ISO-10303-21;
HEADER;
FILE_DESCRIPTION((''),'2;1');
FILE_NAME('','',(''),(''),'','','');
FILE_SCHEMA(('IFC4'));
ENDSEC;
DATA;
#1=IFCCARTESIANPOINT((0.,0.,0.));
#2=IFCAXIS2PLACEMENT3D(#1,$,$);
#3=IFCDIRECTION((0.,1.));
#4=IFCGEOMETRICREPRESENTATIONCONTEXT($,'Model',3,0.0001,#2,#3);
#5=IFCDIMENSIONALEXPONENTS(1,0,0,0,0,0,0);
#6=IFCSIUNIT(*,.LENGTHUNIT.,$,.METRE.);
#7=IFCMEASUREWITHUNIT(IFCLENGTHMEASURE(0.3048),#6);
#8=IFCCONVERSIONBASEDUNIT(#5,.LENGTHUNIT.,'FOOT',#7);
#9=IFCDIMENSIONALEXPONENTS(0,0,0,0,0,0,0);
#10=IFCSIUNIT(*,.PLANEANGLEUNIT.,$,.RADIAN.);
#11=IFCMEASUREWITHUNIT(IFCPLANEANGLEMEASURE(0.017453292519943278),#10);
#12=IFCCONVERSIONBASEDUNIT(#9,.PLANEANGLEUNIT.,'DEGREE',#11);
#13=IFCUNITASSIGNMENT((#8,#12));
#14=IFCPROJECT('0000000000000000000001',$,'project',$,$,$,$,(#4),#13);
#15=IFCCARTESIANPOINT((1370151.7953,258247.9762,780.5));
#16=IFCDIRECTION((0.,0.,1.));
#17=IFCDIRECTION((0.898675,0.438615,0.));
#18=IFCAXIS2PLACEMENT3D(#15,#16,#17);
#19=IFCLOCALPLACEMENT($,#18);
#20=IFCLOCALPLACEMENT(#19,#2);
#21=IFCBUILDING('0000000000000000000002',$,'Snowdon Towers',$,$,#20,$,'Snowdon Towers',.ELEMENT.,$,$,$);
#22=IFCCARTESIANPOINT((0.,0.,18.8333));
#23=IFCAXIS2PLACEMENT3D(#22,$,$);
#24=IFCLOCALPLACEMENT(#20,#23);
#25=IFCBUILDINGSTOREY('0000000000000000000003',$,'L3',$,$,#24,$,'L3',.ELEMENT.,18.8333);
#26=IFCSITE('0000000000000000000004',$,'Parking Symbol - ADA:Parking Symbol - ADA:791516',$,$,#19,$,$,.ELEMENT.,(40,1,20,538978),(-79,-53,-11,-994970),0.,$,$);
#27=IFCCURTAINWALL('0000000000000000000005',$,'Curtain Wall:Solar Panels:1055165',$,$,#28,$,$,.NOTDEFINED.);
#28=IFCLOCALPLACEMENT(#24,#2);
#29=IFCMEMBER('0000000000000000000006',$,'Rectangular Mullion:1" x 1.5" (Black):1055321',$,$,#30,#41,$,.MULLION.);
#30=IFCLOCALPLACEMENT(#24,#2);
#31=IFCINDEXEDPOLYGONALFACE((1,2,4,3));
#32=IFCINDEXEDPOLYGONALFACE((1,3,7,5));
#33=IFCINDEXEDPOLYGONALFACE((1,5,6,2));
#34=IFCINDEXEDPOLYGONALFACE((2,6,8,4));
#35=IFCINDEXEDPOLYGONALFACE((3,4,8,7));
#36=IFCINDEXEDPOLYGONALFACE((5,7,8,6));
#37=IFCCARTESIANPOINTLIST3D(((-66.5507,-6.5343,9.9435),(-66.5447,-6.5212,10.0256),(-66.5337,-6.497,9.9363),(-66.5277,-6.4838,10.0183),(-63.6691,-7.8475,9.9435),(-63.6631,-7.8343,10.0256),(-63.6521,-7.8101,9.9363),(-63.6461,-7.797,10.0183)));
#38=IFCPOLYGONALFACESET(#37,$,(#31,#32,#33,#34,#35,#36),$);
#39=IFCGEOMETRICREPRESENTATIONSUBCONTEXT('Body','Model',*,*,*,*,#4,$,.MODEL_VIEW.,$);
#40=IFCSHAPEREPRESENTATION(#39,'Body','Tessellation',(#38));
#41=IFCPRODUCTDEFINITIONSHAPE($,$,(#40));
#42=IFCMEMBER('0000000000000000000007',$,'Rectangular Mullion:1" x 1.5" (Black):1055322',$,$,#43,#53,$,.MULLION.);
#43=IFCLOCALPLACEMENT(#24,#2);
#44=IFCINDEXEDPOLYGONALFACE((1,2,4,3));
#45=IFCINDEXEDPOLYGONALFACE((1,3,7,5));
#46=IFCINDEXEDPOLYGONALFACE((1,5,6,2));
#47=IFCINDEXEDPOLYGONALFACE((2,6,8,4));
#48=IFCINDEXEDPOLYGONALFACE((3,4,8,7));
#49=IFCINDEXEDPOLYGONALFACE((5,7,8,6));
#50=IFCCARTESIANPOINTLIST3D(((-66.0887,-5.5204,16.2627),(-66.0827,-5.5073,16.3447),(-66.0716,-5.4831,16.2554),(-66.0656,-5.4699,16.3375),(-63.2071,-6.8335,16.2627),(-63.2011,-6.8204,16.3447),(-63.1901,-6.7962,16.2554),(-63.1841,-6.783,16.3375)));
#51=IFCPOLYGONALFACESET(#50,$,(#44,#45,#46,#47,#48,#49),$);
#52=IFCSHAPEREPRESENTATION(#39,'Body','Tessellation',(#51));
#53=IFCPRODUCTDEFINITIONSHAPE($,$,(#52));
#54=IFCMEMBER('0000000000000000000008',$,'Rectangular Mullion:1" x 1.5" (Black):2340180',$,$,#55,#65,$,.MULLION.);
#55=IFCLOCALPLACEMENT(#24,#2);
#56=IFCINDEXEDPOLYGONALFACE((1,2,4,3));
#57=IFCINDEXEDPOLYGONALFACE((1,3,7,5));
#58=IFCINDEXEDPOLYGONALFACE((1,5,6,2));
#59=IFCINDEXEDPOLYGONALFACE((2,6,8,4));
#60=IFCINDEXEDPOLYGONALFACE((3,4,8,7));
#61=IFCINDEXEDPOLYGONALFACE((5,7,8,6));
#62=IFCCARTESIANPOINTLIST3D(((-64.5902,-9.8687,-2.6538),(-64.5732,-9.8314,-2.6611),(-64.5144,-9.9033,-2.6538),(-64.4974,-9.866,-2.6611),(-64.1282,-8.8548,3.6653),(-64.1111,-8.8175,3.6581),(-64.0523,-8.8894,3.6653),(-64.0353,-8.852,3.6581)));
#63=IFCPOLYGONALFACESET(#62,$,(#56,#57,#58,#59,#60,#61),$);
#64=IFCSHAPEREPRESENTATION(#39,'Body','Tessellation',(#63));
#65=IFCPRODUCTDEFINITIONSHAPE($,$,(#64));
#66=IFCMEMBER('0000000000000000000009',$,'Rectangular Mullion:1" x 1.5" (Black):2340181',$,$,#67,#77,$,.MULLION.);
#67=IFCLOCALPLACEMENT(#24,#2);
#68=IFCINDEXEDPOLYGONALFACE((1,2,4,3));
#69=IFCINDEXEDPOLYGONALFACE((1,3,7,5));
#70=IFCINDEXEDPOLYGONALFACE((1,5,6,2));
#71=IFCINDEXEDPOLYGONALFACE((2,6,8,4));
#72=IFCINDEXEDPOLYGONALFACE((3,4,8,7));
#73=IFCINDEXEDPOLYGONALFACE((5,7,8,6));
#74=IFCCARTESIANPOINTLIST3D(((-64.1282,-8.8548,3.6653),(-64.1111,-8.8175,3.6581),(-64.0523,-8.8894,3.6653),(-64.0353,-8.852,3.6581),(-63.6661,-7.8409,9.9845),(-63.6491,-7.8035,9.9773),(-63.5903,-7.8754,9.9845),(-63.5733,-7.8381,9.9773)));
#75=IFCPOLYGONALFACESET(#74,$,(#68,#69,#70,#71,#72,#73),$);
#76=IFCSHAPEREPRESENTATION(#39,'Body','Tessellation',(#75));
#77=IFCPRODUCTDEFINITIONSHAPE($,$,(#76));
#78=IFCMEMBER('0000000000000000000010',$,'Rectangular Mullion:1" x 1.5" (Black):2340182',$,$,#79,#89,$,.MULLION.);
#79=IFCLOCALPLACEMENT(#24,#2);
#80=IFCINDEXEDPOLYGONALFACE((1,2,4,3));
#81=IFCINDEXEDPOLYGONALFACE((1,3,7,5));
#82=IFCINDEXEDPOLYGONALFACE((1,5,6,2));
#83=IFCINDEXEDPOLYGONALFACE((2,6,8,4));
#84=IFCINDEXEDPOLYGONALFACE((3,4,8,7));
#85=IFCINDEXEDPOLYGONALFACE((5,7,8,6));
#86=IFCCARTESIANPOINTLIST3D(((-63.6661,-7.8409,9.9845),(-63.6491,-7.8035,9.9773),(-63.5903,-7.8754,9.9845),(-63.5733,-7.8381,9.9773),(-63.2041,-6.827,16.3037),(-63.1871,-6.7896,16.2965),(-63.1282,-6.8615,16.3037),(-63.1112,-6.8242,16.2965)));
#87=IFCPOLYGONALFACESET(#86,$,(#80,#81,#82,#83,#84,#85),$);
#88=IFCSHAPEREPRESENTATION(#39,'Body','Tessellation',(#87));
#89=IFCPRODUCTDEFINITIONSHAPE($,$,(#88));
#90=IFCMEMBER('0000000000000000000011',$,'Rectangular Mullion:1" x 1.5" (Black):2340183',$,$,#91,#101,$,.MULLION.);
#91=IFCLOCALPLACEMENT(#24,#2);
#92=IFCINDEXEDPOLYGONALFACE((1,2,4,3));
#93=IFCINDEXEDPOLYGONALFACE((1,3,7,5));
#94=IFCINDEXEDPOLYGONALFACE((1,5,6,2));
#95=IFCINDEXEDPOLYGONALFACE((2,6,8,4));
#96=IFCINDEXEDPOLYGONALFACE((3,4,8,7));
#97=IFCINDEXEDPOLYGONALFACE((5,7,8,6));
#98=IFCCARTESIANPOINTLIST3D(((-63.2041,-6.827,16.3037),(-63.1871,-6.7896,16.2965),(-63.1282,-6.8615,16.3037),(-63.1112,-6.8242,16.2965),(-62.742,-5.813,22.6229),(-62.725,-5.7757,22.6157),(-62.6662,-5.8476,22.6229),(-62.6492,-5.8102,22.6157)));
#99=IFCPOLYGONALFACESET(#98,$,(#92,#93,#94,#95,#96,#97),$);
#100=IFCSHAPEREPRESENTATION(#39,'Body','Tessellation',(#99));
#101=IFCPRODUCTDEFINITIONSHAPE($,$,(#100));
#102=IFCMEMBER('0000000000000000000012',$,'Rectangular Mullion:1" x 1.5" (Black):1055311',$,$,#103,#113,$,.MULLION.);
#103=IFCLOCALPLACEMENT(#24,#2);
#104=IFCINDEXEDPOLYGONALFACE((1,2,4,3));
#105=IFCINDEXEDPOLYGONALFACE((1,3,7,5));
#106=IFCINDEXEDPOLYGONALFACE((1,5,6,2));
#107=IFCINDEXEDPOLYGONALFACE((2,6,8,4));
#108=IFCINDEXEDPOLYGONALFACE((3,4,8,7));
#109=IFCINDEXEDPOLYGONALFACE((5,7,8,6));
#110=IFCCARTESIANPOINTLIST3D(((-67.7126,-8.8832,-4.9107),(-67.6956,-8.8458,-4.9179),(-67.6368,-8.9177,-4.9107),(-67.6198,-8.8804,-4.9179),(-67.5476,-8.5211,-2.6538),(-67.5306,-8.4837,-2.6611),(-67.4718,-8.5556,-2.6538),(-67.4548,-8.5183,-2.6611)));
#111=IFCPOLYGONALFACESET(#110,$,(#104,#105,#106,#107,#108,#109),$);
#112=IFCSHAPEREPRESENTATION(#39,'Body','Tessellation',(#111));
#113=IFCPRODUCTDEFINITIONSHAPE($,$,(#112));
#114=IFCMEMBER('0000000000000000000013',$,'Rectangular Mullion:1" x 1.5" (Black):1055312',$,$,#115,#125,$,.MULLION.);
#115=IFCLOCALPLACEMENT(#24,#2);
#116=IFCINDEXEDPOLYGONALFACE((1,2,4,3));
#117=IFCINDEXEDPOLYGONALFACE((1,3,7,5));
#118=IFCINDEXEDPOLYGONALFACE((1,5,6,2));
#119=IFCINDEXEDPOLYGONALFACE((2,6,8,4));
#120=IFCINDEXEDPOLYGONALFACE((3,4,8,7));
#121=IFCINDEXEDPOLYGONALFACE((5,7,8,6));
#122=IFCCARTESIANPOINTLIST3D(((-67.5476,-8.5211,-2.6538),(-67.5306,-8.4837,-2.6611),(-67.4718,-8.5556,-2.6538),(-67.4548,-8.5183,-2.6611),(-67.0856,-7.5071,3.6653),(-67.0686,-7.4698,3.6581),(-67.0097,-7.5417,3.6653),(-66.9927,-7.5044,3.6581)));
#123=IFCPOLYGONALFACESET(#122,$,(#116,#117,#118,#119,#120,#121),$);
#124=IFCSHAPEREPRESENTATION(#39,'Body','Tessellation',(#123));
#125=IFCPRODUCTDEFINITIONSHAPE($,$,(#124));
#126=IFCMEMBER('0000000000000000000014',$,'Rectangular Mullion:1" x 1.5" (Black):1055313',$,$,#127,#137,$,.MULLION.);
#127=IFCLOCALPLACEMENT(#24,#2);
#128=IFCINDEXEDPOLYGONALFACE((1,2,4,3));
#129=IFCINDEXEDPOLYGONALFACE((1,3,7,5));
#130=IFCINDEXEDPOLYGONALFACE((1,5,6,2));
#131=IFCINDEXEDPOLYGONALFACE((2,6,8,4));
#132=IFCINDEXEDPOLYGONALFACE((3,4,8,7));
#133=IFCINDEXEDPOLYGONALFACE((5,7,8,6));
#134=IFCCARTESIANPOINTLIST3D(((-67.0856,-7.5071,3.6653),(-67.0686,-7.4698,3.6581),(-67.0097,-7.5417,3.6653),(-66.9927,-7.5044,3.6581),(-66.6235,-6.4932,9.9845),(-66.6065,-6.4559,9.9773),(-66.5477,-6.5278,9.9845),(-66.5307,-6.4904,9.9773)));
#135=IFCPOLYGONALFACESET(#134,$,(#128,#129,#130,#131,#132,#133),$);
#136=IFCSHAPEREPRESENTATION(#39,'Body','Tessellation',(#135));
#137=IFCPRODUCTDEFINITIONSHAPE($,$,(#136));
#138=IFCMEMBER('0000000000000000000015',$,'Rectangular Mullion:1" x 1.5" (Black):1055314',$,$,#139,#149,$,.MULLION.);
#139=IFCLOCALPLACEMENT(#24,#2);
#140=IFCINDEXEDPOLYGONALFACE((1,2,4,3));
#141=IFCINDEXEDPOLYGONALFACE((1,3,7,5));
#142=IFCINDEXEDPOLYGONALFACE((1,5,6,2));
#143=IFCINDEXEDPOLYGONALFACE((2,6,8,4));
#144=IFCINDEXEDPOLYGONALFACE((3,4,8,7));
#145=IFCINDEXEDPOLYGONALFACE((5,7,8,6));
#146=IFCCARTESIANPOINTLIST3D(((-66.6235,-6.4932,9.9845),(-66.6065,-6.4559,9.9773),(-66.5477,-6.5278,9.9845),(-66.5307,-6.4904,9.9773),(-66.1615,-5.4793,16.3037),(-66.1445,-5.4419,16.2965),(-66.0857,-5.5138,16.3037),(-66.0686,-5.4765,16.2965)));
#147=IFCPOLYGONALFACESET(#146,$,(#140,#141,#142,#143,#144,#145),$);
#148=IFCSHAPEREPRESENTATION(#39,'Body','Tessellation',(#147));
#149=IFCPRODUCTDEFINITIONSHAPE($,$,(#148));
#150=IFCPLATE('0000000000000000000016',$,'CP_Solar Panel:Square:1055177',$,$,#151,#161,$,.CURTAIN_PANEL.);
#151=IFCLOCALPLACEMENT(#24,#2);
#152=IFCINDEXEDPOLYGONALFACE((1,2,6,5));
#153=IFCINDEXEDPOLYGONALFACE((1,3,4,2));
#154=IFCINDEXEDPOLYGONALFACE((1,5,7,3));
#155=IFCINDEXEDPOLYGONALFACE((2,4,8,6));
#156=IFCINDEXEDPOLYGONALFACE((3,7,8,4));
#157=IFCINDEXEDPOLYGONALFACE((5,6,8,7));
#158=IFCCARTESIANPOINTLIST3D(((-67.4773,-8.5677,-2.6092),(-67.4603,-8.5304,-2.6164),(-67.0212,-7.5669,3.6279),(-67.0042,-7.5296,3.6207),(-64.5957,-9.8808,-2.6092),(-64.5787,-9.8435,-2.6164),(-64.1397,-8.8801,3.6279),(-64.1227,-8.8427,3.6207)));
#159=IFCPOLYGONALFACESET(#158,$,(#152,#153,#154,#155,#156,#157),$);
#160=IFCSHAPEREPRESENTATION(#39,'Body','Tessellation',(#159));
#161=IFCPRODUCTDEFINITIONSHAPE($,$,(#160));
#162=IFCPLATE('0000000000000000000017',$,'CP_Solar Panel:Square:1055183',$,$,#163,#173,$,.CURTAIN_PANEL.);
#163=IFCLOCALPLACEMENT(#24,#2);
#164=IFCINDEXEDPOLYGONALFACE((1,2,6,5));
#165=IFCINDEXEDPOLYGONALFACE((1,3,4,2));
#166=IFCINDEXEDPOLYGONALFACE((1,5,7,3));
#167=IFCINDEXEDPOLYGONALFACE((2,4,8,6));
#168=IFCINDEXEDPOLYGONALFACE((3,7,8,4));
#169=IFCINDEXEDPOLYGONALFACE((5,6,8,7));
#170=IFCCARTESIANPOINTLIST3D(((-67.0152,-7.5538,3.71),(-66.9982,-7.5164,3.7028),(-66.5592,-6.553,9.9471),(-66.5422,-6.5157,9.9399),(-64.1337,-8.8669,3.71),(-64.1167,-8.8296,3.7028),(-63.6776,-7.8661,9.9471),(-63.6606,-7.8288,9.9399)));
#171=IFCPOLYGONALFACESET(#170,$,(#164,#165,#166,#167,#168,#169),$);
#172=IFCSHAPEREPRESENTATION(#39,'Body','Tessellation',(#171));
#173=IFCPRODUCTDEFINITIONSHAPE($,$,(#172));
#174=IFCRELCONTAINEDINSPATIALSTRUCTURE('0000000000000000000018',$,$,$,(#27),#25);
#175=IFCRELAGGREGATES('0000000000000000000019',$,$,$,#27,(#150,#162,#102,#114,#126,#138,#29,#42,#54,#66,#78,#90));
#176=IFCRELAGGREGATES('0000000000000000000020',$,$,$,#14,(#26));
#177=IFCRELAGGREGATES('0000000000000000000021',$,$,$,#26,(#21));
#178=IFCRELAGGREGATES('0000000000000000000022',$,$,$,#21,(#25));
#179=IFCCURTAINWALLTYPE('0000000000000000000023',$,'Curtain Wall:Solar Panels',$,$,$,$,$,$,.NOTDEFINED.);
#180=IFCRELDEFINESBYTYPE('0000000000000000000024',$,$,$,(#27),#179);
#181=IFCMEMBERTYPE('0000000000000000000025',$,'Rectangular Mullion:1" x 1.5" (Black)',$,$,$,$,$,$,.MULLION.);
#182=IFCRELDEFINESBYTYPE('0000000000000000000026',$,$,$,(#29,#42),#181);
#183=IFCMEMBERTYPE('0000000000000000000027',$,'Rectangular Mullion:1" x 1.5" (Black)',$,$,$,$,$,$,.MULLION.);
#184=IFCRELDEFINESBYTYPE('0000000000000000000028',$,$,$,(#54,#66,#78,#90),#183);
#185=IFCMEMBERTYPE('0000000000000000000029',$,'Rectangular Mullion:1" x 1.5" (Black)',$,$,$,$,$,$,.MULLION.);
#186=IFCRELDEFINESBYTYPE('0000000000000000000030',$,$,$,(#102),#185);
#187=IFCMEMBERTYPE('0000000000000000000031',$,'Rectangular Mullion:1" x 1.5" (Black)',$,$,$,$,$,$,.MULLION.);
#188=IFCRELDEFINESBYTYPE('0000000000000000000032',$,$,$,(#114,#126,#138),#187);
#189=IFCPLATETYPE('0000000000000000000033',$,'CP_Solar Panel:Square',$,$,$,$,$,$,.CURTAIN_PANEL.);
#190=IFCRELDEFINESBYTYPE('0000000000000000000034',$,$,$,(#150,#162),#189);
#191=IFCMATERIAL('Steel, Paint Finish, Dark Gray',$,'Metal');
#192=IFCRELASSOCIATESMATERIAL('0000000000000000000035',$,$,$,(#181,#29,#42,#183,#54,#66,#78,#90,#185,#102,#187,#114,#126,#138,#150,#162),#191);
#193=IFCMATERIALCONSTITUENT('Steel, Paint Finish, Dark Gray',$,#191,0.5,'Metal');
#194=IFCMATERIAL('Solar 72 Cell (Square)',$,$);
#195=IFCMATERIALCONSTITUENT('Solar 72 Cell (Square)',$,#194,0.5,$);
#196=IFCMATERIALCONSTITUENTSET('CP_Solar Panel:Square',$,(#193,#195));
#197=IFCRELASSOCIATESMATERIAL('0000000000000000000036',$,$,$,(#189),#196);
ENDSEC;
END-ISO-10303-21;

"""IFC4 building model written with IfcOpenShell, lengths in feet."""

from ifc_helpers import new_model, entity, si_unit, converted_unit, direction, frame, origin, place, context, subcontext, project, spatial, indexed_curve, outline, extrude, source, transform, mapped, material, constituent, constituent_set, type_object, type_shapes, element, aggregate, save


model = new_model("IFC4")

# Units and contexts
model_context = context("Model", 3, precision=0.0001, world=origin(), true_north=direction((0.0, 1.0)))
body_context = subcontext(model_context, "Body", "Model", "MODEL_VIEW")
ifc_project = project(units=[converted_unit("LENGTHUNIT", "FOOT", entity("IfcLengthMeasure", 0.3048), si_unit("LENGTHUNIT", "METRE"), dimensions=[1, 0, 0, 0, 0, 0, 0]), converted_unit("PLANEANGLEUNIT", "DEGREE", entity("IfcPlaneAngleMeasure", 0.017453292519943278), si_unit("PLANEANGLEUNIT", "RADIAN"), dimensions=[0, 0, 0, 0, 0, 0, 0])], contexts=[model_context])

# Site, building, storey
site_placement = place(None, frame((1370151.7953, 258247.9762, 780.5), z_axis=(0.0, 0.0, 1.0), x_axis=(0.898675, 0.438615, 0.0)))
site = spatial("IfcSite", under=ifc_project, at=site_placement, Name="Parking Symbol - ADA:Parking Symbol - ADA:791516", CompositionType="ELEMENT", RefLatitude=(40, 1, 20, 538978), RefLongitude=(-79, -53, -11, -994970), RefElevation=0.0)
building_placement = place(site_placement, origin())
building = spatial("IfcBuilding", under=site, at=building_placement, Name="Snowdon Towers", LongName="Snowdon Towers", CompositionType="ELEMENT")
storey_placement = place(building_placement, frame((0.0, 0.0, 18.8333)))
storey = spatial("IfcBuildingStorey", under=building, at=storey_placement, Name="L3", LongName="L3", CompositionType="ELEMENT", Elevation=18.8333)

# Curtain wall, members
curtain_wall_type_1 = type_object("IfcCurtainWallType", Name="Curtain Wall:Solar Panels", PredefinedType="NOTDEFINED")
curtain_wall_1_placement = place(storey_placement, frame((0.0, 0.0, -18.8333)))
curtain_wall_1 = element("IfcCurtainWall", 1, at=curtain_wall_1_placement, inside=storey, type_object=curtain_wall_type_1, Name="Curtain Wall:Solar Panels:1055165", PredefinedType="NOTDEFINED")
ifc_material_1 = material(Name="Steel, Paint Finish, Dark Gray", Category="Metal")
member_type_1 = type_object("IfcMemberType", Name="Rectangular Mullion:1\" x 1.5\" (Black)", PredefinedType="MULLION", material=ifc_material_1)
shared_shape_1 = source(origin(), body_context, "Body", "SweptSolid", [
    extrude(outline(indexed_curve([(-0.0417, -0.0208), (0.0417, -0.0208), (0.0417, 0.0208), (-0.0417, 0.0208), (-0.0417, -0.0208)], self_intersect=False)), frame((0.0, 0.0208, -3.1667), z_axis=(0.0, 0.0, 1.0), x_axis=(-1.0, 0.0, 0.0)), (0.0, 0.0, 1.0), 3.1667),
])
type_shapes(member_type_1, [shared_shape_1])
member_1_placement = place(curtain_wall_1_placement, frame((-63.6491, -7.8035, 28.8106), z_axis=(0.909972, -0.414671, 0.0), x_axis=(0.072007, 0.158015, 0.984808)))
member_1 = element("IfcMember", 2, at=member_1_placement, type_object=member_type_1, material=ifc_material_1, Name="Rectangular Mullion:1\" x 1.5\" (Black):1055321", PredefinedType="MULLION", context=body_context, shape_type="MappedRepresentation", body=[
    mapped(shared_shape_1, transform((0.0, 0.0, 0.0), scale=1.0)),
])
member_2_placement = place(curtain_wall_1_placement, frame((-63.1871, -6.7896, 35.1298), z_axis=(0.909972, -0.414671, 0.0), x_axis=(0.072007, 0.158015, 0.984808)))
member_2 = element("IfcMember", 3, at=member_2_placement, type_object=member_type_1, material=ifc_material_1, Name="Rectangular Mullion:1\" x 1.5\" (Black):1055322", PredefinedType="MULLION", context=body_context, shape_type="MappedRepresentation", body=[
    mapped(shared_shape_1, transform((0.0, 0.0, 0.0), scale=1.0)),
])
member_type_2 = type_object("IfcMemberType", Name="Rectangular Mullion:1\" x 1.5\" (Black)", PredefinedType="MULLION", material=ifc_material_1)
shared_shape_2 = source(origin(), body_context, "Body", "SweptSolid", [
    extrude(outline(indexed_curve([(-0.0417, -0.0208), (0.0417, -0.0208), (0.0417, 0.0208), (-0.0417, 0.0208), (-0.0417, -0.0208)], self_intersect=False)), frame((0.0, 0.0208, -6.4167), z_axis=(0.0, 0.0, 1.0), x_axis=(-1.0, 0.0, 0.0)), (0.0, 0.0, 1.0), 6.4167),
])
type_shapes(member_type_2, [shared_shape_2])
member_3_placement = place(curtain_wall_1_placement, frame((-64.5353, -9.8487, 16.1723), z_axis=(-0.072007, -0.158015, -0.984808), x_axis=(0.909972, -0.414671, 0.0)))
member_3 = element("IfcMember", 4, at=member_3_placement, type_object=member_type_2, material=ifc_material_1, Name="Rectangular Mullion:1\" x 1.5\" (Black):2340180", PredefinedType="MULLION", context=body_context, shape_type="MappedRepresentation", body=[
    mapped(shared_shape_2, transform((0.0, 0.0, 0.0), scale=1.0)),
])
member_4_placement = place(curtain_wall_1_placement, frame((-64.0732, -8.8348, 22.4914), z_axis=(-0.072007, -0.158015, -0.984808), x_axis=(0.909972, -0.414671, 0.0)))
member_4 = element("IfcMember", 5, at=member_4_placement, type_object=member_type_2, material=ifc_material_1, Name="Rectangular Mullion:1\" x 1.5\" (Black):2340181", PredefinedType="MULLION", context=body_context, shape_type="MappedRepresentation", body=[
    mapped(shared_shape_2, transform((0.0, 0.0, 0.0), scale=1.0)),
])
member_5_placement = place(curtain_wall_1_placement, frame((-63.6112, -7.8208, 28.8106), z_axis=(-0.072007, -0.158015, -0.984808), x_axis=(0.909972, -0.414671, 0.0)))
member_5 = element("IfcMember", 6, at=member_5_placement, type_object=member_type_2, material=ifc_material_1, Name="Rectangular Mullion:1\" x 1.5\" (Black):2340182", PredefinedType="MULLION", context=body_context, shape_type="MappedRepresentation", body=[
    mapped(shared_shape_2, transform((0.0, 0.0, 0.0), scale=1.0)),
])
member_6_placement = place(curtain_wall_1_placement, frame((-63.1491, -6.8069, 35.1298), z_axis=(-0.072007, -0.158015, -0.984808), x_axis=(0.909972, -0.414671, 0.0)))
member_6 = element("IfcMember", 7, at=member_6_placement, type_object=member_type_2, material=ifc_material_1, Name="Rectangular Mullion:1\" x 1.5\" (Black):2340183", PredefinedType="MULLION", context=body_context, shape_type="MappedRepresentation", body=[
    mapped(shared_shape_2, transform((0.0, 0.0, 0.0), scale=1.0)),
])
member_type_3 = type_object("IfcMemberType", Name="Rectangular Mullion:1\" x 1.5\" (Black)", PredefinedType="MULLION", material=ifc_material_1)
shared_shape_3 = source(origin(), body_context, "Body", "SweptSolid", [
    extrude(outline(indexed_curve([(-0.0417, -0.0208), (0.0417, -0.0208), (0.0417, 0.0208), (-0.0417, 0.0208), (-0.0417, -0.0208)], self_intersect=False)), frame((-0.0417, 0.0208, -2.2917), z_axis=(0.0, 0.0, 1.0), x_axis=(-1.0, 0.0, 0.0)), (0.0, 0.0, 1.0), 2.2917),
])
type_shapes(member_type_3, [shared_shape_3])
member_7_placement = place(curtain_wall_1_placement, frame((-67.5306, -8.4837, 16.1723), z_axis=(0.072007, 0.158015, 0.984808), x_axis=(-0.909972, 0.414671, 0.0)))
member_7 = element("IfcMember", 8, at=member_7_placement, type_object=member_type_3, material=ifc_material_1, Name="Rectangular Mullion:1\" x 1.5\" (Black):1055311", PredefinedType="MULLION", context=body_context, shape_type="MappedRepresentation", body=[
    mapped(shared_shape_3, transform((0.0, 0.0, 0.0), scale=1.0)),
])
member_type_4 = type_object("IfcMemberType", Name="Rectangular Mullion:1\" x 1.5\" (Black)", PredefinedType="MULLION", material=ifc_material_1)
shared_shape_4 = source(origin(), body_context, "Body", "SweptSolid", [
    extrude(outline(indexed_curve([(-0.0417, -0.0208), (0.0417, -0.0208), (0.0417, 0.0208), (-0.0417, 0.0208), (-0.0417, -0.0208)], self_intersect=False)), frame((-0.0417, 0.0208, -6.4167), z_axis=(0.0, 0.0, 1.0), x_axis=(-1.0, 0.0, 0.0)), (0.0, 0.0, 1.0), 6.4167),
])
type_shapes(member_type_4, [shared_shape_4])
member_8_placement = place(curtain_wall_1_placement, frame((-67.0686, -7.4698, 22.4914), z_axis=(0.072007, 0.158015, 0.984808), x_axis=(-0.909972, 0.414671, 0.0)))
member_8 = element("IfcMember", 9, at=member_8_placement, type_object=member_type_4, material=ifc_material_1, Name="Rectangular Mullion:1\" x 1.5\" (Black):1055312", PredefinedType="MULLION", context=body_context, shape_type="MappedRepresentation", body=[
    mapped(shared_shape_4, transform((0.0, 0.0, 0.0), scale=1.0)),
])
member_9_placement = place(curtain_wall_1_placement, frame((-66.6065, -6.4559, 28.8106), z_axis=(0.072007, 0.158015, 0.984808), x_axis=(-0.909972, 0.414671, 0.0)))
member_9 = element("IfcMember", 10, at=member_9_placement, type_object=member_type_4, material=ifc_material_1, Name="Rectangular Mullion:1\" x 1.5\" (Black):1055313", PredefinedType="MULLION", context=body_context, shape_type="MappedRepresentation", body=[
    mapped(shared_shape_4, transform((0.0, 0.0, 0.0), scale=1.0)),
])
member_10_placement = place(curtain_wall_1_placement, frame((-66.1445, -5.4419, 35.1298), z_axis=(0.072007, 0.158015, 0.984808), x_axis=(-0.909972, 0.414671, 0.0)))
member_10 = element("IfcMember", 11, at=member_10_placement, type_object=member_type_4, material=ifc_material_1, Name="Rectangular Mullion:1\" x 1.5\" (Black):1055314", PredefinedType="MULLION", context=body_context, shape_type="MappedRepresentation", body=[
    mapped(shared_shape_4, transform((0.0, 0.0, 0.0), scale=1.0)),
])

# Plates
ifc_constituent_1 = constituent(ifc_material_1, Name="Steel, Paint Finish, Dark Gray", Category="Metal", fraction=0.5)
ifc_material_2 = material(Name="Solar 72 Cell (Square)")
ifc_constituent_2 = constituent(ifc_material_2, Name="Solar 72 Cell (Square)", fraction=0.5)
ifc_constituent_set_1 = constituent_set(constituents=[ifc_constituent_1, ifc_constituent_2], Name="CP_Solar Panel:Square")
plate_type_1 = type_object("IfcPlateType", Name="CP_Solar Panel:Square", PredefinedType="CURTAIN_PANEL", material=ifc_constituent_set_1)
shared_shape_5 = source(origin(), body_context, "Body", "SweptSolid", [
    extrude(outline(indexed_curve([(-1.5833, -0.0208), (1.5833, -0.0208), (1.5833, 0.0208), (-1.5833, 0.0208), (-1.5833, -0.0208)], self_intersect=False)), frame((0.0, -0.0417, 0.0)), (0.0, 0.0, 1.0), 6.3333),
])
type_shapes(plate_type_1, [shared_shape_5])
plate_1_placement = place(curtain_wall_1_placement, frame((-66.011, -9.1683, 16.2133), z_axis=(0.072007, 0.158015, 0.984808), x_axis=(0.909972, -0.414671, 0.0)))
plate_1 = element("IfcPlate", 12, at=plate_1_placement, type_object=plate_type_1, material=ifc_material_1, Name="CP_Solar Panel:Square:1055177", PredefinedType="CURTAIN_PANEL", context=body_context, shape_type="MappedRepresentation", body=[
    mapped(shared_shape_5, transform((0.0, 0.0, 0.0), scale=1.0)),
])
plate_2_placement = place(curtain_wall_1_placement, frame((-65.5489, -8.1543, 22.5325), z_axis=(0.072007, 0.158015, 0.984808), x_axis=(0.909972, -0.414671, 0.0)))
plate_2 = element("IfcPlate", 13, at=plate_2_placement, type_object=plate_type_1, material=ifc_material_1, Name="CP_Solar Panel:Square:1055183", PredefinedType="CURTAIN_PANEL", context=body_context, shape_type="MappedRepresentation", body=[
    mapped(shared_shape_5, transform((0.0, 0.0, 0.0), scale=1.0)),
])
aggregate(curtain_wall_1, [plate_1, plate_2, member_7, member_8, member_9, member_10, member_1, member_2, member_3, member_4, member_5, member_6])

save(model, "model.ifc")
